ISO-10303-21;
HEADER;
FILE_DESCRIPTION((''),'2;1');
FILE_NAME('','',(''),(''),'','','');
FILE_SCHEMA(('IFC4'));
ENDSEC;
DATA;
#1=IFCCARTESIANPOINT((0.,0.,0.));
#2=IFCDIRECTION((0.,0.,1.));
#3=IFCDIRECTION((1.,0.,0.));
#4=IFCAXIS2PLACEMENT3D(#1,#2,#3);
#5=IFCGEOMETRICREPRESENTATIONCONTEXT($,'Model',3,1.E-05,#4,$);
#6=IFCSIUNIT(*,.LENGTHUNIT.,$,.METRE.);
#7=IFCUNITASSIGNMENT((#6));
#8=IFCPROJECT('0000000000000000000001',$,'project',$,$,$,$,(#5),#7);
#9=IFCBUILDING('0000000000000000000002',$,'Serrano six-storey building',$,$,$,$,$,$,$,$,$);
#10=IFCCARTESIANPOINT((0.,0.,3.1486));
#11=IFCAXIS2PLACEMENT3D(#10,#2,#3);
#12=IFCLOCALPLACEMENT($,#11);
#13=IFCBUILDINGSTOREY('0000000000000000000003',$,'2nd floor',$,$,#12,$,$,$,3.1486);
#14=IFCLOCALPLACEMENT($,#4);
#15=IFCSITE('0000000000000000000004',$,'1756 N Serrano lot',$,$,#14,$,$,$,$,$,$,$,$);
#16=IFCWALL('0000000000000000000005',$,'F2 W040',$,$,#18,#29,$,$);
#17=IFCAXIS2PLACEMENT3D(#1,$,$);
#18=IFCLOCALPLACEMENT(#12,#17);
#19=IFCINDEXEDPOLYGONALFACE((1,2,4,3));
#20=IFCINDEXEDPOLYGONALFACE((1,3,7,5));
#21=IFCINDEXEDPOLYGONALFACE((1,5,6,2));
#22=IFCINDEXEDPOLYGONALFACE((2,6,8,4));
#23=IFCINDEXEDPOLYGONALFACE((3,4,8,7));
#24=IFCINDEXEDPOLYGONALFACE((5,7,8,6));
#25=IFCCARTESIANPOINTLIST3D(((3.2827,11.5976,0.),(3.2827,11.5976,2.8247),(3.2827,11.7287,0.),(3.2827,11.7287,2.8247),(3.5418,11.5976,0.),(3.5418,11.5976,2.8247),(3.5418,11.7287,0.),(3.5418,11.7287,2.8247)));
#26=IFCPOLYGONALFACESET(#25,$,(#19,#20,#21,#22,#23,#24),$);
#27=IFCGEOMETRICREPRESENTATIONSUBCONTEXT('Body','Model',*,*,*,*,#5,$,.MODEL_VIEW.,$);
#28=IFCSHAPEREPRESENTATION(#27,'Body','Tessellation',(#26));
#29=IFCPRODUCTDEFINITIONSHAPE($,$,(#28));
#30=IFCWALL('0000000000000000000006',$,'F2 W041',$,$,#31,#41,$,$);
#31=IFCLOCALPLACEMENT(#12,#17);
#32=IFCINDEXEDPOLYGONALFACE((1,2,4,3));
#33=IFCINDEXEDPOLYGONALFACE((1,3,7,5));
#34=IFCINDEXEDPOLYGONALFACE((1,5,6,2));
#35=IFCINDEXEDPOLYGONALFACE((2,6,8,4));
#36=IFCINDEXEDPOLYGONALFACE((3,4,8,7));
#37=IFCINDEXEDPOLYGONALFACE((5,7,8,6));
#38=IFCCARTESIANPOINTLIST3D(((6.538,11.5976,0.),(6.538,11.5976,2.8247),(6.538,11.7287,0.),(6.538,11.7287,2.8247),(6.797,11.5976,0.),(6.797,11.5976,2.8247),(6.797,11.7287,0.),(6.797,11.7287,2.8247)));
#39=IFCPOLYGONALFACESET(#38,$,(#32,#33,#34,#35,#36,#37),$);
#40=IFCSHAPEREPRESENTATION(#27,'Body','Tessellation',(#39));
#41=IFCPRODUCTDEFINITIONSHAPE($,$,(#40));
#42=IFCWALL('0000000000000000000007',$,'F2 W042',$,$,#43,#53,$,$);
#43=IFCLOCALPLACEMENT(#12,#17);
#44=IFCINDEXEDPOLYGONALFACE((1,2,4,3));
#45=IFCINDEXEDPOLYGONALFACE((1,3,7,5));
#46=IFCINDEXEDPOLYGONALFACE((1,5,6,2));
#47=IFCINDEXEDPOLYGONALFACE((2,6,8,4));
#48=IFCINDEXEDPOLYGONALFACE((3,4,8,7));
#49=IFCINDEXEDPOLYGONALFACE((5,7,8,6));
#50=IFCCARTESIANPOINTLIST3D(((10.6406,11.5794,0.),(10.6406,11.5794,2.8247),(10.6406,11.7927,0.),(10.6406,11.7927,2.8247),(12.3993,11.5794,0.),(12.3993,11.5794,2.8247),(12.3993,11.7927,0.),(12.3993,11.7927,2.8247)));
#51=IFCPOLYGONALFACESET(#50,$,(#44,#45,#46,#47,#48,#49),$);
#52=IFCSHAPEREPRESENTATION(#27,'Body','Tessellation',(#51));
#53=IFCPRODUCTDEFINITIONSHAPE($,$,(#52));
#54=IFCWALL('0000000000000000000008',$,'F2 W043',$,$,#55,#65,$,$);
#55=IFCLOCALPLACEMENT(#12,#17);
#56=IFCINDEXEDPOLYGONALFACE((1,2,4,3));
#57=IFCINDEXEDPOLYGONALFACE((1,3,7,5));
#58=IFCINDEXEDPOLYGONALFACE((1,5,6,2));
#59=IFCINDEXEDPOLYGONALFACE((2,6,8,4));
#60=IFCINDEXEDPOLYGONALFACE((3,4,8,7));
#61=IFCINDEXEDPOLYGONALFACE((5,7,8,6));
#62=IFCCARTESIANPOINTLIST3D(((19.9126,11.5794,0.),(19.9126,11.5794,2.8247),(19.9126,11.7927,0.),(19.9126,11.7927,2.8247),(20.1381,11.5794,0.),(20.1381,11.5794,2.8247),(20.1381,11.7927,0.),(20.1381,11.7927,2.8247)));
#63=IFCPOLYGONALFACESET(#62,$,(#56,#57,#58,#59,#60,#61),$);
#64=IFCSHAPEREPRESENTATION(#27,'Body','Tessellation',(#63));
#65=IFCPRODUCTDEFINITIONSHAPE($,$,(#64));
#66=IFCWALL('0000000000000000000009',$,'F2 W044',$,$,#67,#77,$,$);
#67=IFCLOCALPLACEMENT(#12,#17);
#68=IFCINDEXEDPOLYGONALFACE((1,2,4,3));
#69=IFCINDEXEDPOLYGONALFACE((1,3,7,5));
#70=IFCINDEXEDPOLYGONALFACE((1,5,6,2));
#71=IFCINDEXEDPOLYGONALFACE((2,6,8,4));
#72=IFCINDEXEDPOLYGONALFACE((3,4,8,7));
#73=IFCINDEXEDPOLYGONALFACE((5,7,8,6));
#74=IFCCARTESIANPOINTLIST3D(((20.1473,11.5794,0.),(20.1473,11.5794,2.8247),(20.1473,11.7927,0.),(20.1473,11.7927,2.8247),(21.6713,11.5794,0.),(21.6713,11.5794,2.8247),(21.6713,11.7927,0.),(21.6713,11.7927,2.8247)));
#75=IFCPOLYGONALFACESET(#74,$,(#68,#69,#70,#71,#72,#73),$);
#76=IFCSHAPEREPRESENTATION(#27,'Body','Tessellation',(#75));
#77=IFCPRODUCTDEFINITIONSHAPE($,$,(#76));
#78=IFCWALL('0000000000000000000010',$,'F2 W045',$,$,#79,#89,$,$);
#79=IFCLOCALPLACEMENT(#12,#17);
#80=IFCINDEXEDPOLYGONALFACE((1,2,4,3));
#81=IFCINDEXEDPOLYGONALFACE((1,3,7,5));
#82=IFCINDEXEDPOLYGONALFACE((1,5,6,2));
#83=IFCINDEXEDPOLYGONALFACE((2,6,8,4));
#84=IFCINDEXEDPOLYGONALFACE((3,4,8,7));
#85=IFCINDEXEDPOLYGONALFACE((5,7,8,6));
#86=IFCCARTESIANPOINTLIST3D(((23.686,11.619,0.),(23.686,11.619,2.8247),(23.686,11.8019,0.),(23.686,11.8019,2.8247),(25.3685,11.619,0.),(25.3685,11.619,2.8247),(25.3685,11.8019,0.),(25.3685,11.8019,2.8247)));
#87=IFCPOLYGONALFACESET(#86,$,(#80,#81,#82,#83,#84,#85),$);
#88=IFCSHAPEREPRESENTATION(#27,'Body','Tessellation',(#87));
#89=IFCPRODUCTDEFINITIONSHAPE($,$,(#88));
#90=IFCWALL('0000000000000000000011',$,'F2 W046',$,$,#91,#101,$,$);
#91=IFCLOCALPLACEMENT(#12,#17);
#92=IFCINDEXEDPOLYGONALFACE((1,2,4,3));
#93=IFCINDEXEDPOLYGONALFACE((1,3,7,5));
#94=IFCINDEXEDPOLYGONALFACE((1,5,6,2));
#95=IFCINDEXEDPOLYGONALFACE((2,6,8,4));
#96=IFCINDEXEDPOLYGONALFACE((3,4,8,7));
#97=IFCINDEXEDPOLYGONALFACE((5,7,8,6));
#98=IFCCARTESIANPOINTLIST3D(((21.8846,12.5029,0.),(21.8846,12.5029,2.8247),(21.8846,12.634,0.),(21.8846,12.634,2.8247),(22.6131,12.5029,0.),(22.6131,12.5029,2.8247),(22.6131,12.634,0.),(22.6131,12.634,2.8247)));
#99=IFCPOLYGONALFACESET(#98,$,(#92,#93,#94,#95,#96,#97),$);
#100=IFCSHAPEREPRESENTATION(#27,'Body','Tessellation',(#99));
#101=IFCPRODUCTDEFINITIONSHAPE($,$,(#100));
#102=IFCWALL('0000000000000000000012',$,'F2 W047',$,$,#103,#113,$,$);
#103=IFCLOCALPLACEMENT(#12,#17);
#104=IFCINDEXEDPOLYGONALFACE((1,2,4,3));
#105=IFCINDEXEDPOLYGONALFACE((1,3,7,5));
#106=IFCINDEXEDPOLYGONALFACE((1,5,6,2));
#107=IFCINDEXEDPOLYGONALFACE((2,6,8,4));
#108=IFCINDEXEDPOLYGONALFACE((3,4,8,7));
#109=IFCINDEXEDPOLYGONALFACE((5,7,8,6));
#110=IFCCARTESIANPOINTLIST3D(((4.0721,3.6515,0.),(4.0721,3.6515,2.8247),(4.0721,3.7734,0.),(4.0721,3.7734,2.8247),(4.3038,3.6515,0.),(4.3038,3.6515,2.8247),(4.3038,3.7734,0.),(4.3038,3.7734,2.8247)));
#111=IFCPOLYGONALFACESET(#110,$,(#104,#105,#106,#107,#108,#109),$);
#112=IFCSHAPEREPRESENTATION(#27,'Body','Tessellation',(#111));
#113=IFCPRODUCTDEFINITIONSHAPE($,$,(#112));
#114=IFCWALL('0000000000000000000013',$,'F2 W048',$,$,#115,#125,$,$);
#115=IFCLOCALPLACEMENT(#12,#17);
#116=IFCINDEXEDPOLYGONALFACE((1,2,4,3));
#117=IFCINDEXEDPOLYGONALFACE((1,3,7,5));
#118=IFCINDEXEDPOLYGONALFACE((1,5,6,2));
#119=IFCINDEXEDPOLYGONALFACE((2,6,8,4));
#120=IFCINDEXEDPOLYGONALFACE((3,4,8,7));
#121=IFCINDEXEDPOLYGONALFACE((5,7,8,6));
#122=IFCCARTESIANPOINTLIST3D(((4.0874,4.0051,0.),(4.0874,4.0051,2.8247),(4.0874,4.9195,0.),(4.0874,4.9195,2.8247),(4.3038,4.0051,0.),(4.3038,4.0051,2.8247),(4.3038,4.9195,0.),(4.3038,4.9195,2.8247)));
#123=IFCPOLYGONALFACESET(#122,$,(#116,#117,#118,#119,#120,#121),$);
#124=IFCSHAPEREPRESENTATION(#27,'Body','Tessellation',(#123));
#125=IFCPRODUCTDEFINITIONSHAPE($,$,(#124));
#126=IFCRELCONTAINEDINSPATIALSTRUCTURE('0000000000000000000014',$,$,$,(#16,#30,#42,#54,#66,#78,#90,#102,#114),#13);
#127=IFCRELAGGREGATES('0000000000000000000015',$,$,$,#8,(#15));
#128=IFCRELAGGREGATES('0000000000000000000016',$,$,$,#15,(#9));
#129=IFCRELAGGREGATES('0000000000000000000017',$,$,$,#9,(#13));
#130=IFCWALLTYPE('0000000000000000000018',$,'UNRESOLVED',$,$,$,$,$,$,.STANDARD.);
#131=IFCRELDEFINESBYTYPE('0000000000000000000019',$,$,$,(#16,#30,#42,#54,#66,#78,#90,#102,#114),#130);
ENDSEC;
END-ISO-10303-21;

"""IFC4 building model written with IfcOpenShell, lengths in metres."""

from ifc_helpers import new_model, si_unit, frame, origin_with_axes, place, context, subcontext, project, spatial, polyline, outline, extrude, type_object, element, save


model = new_model("IFC4")

# Units and contexts
model_context = context("Model", 3, precision=1e-05, world=origin_with_axes())
body_context = subcontext(model_context, "Body", "Model", "MODEL_VIEW")
ifc_project = project(units=[si_unit("LENGTHUNIT", "METRE")], contexts=[model_context])

# Site, building, storey
site_placement = place(None, origin_with_axes())
site = spatial("IfcSite", under=ifc_project, at=site_placement, Name="1756 N Serrano lot")
building = spatial("IfcBuilding", under=site, Name="Serrano six-storey building")
storey_placement = place(None, frame((0.0, 0.0, 3.1486), z_axis=(0.0, 0.0, 1.0), x_axis=(1.0, 0.0, 0.0)))
storey = spatial("IfcBuildingStorey", under=building, at=storey_placement, Name="2nd floor", Elevation=3.1486)

# Walls
wall_type_1 = type_object("IfcWallType", Name="UNRESOLVED", PredefinedType="STANDARD")
wall_1_placement = place(storey_placement, frame((0.0, 0.0, -3.1486), z_axis=(0.0, 0.0, 1.0), x_axis=(1.0, 0.0, 0.0)))
element("IfcWall", 1, at=wall_1_placement, inside=storey, type_object=wall_type_1, Name="F2 W040", context=body_context, shape_type="SweptSolid", body=[
    extrude(outline(polyline([(3.5418, 11.7287), (3.5418, 11.5976), (3.2827, 11.5976), (3.2827, 11.7287), (3.5418, 11.7287)])), frame((0.0, 0.0, 3.1486)), (0.0, 0.0, 1.0), 2.8247),
])
wall_2_placement = place(storey_placement, frame((0.0, 0.0, -3.1486), z_axis=(0.0, 0.0, 1.0), x_axis=(1.0, 0.0, 0.0)))
element("IfcWall", 2, at=wall_2_placement, inside=storey, type_object=wall_type_1, Name="F2 W041", context=body_context, shape_type="SweptSolid", body=[
    extrude(outline(polyline([(6.797, 11.7287), (6.797, 11.5976), (6.538, 11.5976), (6.538, 11.7287), (6.797, 11.7287)])), frame((0.0, 0.0, 3.1486)), (0.0, 0.0, 1.0), 2.8247),
])
wall_3_placement = place(storey_placement, frame((0.0, 0.0, -3.1486), z_axis=(0.0, 0.0, 1.0), x_axis=(1.0, 0.0, 0.0)))
element("IfcWall", 3, at=wall_3_placement, inside=storey, type_object=wall_type_1, Name="F2 W042", context=body_context, shape_type="SweptSolid", body=[
    extrude(outline(polyline([(12.3993, 11.7927), (12.3993, 11.5794), (10.6406, 11.5794), (10.6406, 11.7927), (12.3993, 11.7927)])), frame((0.0, 0.0, 3.1486)), (0.0, 0.0, 1.0), 2.8247),
])
wall_4_placement = place(storey_placement, frame((0.0, 0.0, -3.1486), z_axis=(0.0, 0.0, 1.0), x_axis=(1.0, 0.0, 0.0)))
element("IfcWall", 4, at=wall_4_placement, inside=storey, type_object=wall_type_1, Name="F2 W043", context=body_context, shape_type="SweptSolid", body=[
    extrude(outline(polyline([(20.1381, 11.7927), (20.1381, 11.5794), (19.9126, 11.5794), (19.9126, 11.7927), (20.1381, 11.7927)])), frame((0.0, 0.0, 3.1486)), (0.0, 0.0, 1.0), 2.8247),
])
wall_5_placement = place(storey_placement, frame((0.0, 0.0, -3.1486), z_axis=(0.0, 0.0, 1.0), x_axis=(1.0, 0.0, 0.0)))
element("IfcWall", 5, at=wall_5_placement, inside=storey, type_object=wall_type_1, Name="F2 W044", context=body_context, shape_type="SweptSolid", body=[
    extrude(outline(polyline([(21.6713, 11.7927), (21.6713, 11.5794), (20.1473, 11.5794), (20.1473, 11.7927), (21.6713, 11.7927)])), frame((0.0, 0.0, 3.1486)), (0.0, 0.0, 1.0), 2.8247),
])
wall_6_placement = place(storey_placement, frame((0.0, 0.0, -3.1486), z_axis=(0.0, 0.0, 1.0), x_axis=(1.0, 0.0, 0.0)))
element("IfcWall", 6, at=wall_6_placement, inside=storey, type_object=wall_type_1, Name="F2 W045", context=body_context, shape_type="SweptSolid", body=[
    extrude(outline(polyline([(25.3685, 11.8019), (25.3685, 11.619), (23.686, 11.619), (23.686, 11.8019), (25.3685, 11.8019)])), frame((0.0, 0.0, 3.1486)), (0.0, 0.0, 1.0), 2.8247),
])
wall_7_placement = place(storey_placement, frame((0.0, 0.0, -3.1486), z_axis=(0.0, 0.0, 1.0), x_axis=(1.0, 0.0, 0.0)))
element("IfcWall", 7, at=wall_7_placement, inside=storey, type_object=wall_type_1, Name="F2 W046", context=body_context, shape_type="SweptSolid", body=[
    extrude(outline(polyline([(22.6131, 12.634), (22.6131, 12.5029), (21.8846, 12.5029), (21.8846, 12.634), (22.6131, 12.634)])), frame((0.0, 0.0, 3.1486)), (0.0, 0.0, 1.0), 2.8247),
])
wall_8_placement = place(storey_placement, frame((0.0, 0.0, -3.1486), z_axis=(0.0, 0.0, 1.0), x_axis=(1.0, 0.0, 0.0)))
element("IfcWall", 8, at=wall_8_placement, inside=storey, type_object=wall_type_1, Name="F2 W047", context=body_context, shape_type="SweptSolid", body=[
    extrude(outline(polyline([(4.0721, 3.7734), (4.3038, 3.7734), (4.3038, 3.6515), (4.0721, 3.6515), (4.0721, 3.7734)])), frame((0.0, 0.0, 3.1486)), (0.0, 0.0, 1.0), 2.8247),
])
wall_9_placement = place(storey_placement, frame((0.0, 0.0, -3.1486), z_axis=(0.0, 0.0, 1.0), x_axis=(1.0, 0.0, 0.0)))
element("IfcWall", 9, at=wall_9_placement, inside=storey, type_object=wall_type_1, Name="F2 W048", context=body_context, shape_type="SweptSolid", body=[
    extrude(outline(polyline([(4.0874, 4.9195), (4.3038, 4.9195), (4.3038, 4.0051), (4.0874, 4.0051), (4.0874, 4.9195)])), frame((0.0, 0.0, 3.1486)), (0.0, 0.0, 1.0), 2.8247),
])

save(model, "model.ifc")
